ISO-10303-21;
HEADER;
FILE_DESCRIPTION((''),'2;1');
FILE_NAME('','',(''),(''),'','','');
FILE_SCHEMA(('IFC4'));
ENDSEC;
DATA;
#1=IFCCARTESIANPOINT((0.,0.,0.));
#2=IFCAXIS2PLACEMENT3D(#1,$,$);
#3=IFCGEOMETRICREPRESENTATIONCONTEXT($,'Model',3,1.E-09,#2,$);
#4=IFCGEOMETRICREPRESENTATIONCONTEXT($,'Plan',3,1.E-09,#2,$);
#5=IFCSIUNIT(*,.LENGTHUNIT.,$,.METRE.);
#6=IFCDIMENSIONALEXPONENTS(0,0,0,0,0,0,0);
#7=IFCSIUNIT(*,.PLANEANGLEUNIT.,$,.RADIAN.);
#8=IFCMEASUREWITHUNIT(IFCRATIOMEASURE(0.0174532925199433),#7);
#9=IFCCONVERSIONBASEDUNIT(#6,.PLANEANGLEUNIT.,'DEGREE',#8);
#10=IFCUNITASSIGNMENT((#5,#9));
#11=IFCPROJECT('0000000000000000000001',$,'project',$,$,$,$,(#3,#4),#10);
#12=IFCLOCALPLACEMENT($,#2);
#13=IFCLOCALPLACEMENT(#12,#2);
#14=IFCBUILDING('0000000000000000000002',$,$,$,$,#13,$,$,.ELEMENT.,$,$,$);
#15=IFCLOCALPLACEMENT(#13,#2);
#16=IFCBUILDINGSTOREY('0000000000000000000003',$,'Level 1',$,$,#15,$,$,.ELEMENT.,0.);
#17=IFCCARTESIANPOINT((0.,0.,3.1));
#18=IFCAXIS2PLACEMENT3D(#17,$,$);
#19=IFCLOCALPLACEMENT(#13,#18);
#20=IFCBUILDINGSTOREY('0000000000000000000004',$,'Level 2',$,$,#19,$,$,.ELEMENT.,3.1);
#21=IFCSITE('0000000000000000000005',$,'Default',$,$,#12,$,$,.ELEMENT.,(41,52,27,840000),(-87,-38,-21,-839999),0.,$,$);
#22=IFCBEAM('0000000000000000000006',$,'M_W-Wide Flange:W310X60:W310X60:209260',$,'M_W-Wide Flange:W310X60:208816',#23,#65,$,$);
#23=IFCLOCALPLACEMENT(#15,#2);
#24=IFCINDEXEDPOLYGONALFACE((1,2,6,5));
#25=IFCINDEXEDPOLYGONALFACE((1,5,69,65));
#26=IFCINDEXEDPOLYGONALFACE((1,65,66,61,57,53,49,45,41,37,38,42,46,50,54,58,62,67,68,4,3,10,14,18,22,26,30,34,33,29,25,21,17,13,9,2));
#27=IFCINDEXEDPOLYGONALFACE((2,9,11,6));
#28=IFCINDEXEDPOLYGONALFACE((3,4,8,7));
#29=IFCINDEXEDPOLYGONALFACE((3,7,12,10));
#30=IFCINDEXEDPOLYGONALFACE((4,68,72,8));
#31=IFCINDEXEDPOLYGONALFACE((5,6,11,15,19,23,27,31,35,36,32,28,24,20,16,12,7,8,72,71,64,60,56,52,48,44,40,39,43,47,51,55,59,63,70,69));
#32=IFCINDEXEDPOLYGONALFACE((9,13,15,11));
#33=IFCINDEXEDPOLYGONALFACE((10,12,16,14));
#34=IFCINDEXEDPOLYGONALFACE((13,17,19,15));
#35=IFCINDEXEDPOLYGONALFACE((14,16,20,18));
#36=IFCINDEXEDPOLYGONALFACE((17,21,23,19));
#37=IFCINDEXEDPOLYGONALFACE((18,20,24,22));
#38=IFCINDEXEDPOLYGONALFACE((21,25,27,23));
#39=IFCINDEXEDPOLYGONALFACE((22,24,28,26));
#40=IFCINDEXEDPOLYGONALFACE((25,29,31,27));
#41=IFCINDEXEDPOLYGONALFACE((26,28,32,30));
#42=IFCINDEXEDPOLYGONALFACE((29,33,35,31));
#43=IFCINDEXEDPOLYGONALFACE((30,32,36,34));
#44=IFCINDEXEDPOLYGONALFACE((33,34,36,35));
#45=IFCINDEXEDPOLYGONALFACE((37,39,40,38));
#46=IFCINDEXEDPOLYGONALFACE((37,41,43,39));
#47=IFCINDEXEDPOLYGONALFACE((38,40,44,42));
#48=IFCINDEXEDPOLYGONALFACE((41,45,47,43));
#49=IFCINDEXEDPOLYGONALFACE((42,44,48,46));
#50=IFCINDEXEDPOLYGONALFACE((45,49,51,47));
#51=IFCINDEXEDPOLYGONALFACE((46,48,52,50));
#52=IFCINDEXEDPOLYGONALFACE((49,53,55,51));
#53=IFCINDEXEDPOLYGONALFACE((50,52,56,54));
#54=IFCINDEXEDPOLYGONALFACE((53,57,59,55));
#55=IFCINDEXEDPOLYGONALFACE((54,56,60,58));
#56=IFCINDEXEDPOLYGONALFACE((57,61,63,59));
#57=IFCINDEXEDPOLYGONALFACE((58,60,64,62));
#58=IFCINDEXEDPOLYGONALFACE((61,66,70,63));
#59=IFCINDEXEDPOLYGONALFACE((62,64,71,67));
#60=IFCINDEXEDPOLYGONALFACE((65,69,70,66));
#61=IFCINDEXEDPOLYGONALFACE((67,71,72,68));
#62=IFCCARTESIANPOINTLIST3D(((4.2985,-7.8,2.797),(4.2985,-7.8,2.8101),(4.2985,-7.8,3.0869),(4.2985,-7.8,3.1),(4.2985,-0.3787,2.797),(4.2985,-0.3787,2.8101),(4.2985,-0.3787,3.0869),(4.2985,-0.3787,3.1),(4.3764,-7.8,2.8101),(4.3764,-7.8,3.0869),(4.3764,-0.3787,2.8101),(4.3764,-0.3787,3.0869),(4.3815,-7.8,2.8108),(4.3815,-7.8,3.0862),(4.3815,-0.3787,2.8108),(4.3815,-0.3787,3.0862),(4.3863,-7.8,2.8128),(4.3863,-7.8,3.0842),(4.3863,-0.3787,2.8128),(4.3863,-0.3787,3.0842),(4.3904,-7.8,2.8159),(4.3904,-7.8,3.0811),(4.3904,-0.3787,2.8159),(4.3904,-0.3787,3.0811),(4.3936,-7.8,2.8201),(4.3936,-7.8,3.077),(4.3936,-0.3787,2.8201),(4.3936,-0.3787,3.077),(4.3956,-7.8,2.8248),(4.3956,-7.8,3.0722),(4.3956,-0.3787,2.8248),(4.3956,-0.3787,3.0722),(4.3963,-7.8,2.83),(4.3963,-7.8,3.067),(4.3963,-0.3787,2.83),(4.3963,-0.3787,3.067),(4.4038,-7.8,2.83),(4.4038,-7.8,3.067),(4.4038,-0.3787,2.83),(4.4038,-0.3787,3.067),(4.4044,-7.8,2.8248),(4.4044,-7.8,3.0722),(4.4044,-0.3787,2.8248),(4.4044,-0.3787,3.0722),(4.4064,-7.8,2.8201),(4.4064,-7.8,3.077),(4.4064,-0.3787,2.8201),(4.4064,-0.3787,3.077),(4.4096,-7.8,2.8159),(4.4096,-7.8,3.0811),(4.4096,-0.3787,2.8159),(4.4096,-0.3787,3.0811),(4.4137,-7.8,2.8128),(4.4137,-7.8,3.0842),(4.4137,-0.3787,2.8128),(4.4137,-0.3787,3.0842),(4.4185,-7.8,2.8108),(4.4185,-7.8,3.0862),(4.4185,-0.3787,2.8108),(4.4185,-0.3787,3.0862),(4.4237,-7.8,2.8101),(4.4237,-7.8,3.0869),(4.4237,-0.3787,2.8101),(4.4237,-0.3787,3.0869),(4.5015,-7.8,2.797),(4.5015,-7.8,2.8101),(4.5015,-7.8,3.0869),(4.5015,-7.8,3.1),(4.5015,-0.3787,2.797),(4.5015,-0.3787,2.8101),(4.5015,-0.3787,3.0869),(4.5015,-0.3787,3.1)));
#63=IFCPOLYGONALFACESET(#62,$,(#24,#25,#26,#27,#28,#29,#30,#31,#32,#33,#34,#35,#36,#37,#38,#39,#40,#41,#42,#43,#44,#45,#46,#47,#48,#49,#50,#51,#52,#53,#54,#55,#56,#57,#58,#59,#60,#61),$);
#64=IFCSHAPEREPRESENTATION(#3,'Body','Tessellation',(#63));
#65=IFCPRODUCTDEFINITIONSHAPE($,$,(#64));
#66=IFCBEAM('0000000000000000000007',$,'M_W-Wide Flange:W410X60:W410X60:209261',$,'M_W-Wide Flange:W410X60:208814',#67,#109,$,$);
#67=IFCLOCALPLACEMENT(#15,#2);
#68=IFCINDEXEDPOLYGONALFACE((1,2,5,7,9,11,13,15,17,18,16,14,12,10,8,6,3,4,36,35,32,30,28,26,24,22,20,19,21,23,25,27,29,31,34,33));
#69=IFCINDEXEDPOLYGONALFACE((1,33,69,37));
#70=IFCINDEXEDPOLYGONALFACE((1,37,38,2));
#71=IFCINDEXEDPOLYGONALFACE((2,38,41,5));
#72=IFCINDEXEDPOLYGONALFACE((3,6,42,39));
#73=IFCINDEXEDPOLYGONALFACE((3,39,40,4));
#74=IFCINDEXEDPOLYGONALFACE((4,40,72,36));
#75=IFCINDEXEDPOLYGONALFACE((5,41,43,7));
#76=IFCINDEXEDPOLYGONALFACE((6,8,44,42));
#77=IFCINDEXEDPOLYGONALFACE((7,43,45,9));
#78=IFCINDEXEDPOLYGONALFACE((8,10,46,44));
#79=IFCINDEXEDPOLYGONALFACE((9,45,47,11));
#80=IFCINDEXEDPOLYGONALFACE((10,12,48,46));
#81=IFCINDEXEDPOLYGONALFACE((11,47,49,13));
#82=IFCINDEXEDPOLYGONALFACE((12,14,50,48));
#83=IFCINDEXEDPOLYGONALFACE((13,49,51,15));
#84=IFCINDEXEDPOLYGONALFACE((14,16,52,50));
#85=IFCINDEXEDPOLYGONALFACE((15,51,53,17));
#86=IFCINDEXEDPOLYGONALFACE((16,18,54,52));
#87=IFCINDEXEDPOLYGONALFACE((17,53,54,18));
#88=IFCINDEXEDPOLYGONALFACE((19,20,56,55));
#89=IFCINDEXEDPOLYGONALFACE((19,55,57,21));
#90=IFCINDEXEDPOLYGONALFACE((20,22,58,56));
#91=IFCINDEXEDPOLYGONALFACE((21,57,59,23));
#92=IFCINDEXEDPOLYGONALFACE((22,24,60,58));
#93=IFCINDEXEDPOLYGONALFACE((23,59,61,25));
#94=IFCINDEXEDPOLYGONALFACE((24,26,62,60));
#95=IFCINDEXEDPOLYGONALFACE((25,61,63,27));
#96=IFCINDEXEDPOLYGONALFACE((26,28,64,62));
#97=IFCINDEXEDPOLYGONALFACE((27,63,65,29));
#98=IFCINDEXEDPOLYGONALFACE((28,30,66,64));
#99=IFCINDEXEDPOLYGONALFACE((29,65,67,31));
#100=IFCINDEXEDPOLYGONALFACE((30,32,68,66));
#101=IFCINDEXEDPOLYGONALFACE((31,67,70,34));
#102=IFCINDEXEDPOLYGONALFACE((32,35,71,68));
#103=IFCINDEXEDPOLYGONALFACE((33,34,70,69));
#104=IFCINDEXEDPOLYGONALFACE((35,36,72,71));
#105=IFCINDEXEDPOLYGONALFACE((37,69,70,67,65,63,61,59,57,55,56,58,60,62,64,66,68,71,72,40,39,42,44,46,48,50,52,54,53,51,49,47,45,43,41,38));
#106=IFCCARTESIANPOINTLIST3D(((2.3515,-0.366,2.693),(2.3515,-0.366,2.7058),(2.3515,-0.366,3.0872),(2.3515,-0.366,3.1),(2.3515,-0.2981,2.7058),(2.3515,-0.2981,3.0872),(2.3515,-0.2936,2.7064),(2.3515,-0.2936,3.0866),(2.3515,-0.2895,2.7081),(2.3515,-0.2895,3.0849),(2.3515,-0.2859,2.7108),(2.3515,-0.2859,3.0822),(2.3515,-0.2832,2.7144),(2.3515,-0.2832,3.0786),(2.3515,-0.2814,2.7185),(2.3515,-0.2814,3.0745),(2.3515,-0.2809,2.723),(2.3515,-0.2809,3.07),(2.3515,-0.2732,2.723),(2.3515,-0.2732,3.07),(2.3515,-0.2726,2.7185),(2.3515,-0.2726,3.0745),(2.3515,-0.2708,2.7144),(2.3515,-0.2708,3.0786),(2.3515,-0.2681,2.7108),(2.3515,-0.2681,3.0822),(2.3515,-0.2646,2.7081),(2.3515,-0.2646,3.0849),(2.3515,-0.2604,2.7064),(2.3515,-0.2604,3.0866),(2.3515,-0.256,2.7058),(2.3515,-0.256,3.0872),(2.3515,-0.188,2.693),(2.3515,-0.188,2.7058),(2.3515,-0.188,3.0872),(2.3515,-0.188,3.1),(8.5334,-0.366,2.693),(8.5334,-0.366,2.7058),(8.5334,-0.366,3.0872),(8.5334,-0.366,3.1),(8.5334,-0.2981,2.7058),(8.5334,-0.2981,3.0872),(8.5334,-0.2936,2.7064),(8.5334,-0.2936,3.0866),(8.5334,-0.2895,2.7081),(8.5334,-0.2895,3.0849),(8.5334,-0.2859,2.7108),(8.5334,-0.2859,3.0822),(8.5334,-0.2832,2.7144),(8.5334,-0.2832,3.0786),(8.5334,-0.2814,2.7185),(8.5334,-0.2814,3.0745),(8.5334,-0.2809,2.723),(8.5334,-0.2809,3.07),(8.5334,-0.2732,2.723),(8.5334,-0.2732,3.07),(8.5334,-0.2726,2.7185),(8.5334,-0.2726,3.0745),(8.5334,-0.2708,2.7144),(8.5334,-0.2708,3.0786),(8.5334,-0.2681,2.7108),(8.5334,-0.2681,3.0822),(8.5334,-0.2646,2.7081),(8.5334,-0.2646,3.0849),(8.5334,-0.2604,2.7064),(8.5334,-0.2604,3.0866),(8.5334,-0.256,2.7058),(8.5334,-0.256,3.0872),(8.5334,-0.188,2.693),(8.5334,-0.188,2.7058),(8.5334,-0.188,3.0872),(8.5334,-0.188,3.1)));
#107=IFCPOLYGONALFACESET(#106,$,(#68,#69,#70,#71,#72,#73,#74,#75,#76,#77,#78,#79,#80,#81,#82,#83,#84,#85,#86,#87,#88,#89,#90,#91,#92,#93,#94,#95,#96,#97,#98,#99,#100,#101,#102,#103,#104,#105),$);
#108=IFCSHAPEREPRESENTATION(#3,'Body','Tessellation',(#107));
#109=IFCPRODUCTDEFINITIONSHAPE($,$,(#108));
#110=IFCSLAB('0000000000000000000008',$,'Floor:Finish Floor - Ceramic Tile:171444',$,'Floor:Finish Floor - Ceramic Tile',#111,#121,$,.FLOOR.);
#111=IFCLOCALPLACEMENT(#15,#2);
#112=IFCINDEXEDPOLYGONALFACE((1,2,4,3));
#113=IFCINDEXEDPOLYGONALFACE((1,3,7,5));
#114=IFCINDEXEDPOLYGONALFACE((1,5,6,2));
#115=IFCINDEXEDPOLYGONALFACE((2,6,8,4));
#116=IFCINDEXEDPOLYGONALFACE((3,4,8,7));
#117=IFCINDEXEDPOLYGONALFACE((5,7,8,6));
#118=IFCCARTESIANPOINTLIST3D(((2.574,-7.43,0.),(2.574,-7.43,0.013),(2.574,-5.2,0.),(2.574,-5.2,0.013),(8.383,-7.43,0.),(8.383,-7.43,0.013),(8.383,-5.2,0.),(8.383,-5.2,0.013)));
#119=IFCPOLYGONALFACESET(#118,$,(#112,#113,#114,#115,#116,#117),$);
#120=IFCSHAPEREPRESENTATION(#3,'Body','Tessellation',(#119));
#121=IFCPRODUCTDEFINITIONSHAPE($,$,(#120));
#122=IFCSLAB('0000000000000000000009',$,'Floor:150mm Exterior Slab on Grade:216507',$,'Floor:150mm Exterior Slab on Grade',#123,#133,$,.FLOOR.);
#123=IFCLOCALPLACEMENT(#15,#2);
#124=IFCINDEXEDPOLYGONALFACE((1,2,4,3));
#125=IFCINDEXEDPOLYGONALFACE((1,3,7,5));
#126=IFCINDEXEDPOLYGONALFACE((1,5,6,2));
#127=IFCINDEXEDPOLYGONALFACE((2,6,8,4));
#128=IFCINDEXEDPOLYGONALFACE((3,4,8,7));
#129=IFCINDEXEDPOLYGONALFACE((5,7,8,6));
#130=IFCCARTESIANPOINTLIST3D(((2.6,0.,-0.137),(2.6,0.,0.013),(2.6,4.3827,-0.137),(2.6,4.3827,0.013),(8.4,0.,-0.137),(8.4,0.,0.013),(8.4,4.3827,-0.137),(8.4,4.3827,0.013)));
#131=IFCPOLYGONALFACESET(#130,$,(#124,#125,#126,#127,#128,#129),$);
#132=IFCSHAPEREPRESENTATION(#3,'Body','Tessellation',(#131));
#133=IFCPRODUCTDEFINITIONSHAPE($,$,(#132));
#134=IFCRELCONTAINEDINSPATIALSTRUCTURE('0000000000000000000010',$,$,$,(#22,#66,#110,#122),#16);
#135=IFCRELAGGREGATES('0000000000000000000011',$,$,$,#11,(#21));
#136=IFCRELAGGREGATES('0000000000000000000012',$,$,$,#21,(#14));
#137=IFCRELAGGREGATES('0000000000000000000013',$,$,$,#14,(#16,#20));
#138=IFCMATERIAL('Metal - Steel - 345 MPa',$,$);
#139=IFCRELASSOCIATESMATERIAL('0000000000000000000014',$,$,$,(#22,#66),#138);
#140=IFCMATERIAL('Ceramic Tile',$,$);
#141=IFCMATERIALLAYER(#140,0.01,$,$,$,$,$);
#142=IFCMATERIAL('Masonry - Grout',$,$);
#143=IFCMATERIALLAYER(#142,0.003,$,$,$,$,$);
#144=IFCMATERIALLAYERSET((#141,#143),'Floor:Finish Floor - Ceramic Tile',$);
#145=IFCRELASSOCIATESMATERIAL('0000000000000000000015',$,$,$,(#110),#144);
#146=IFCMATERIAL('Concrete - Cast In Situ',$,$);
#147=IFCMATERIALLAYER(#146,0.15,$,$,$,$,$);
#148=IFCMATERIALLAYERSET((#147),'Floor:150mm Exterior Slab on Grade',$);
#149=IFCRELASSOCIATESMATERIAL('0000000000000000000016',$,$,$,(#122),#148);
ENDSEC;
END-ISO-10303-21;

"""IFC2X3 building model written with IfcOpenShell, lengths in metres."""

from ifc_helpers import new_model, entity, si_unit, converted_unit, frame, frame_2d, origin, place, context, project, spatial, polyline, circle_curve, parameter, trimmed, segment, composite_curve, rectangle, outline, extrude, material, layer, layer_set, layer_usage, element, save


model = new_model("IFC2X3")

# Units and contexts
model_context = context("Model", 3, precision=1e-09, world=origin())
plan_context = context("Plan", 3, precision=1e-09, world=origin())
ifc_project = project(units=[si_unit("LENGTHUNIT", "METRE"), converted_unit("PLANEANGLEUNIT", "DEGREE", entity("IfcRatioMeasure", 0.0174532925199433), si_unit("PLANEANGLEUNIT", "RADIAN"), dimensions=[0, 0, 0, 0, 0, 0, 0])], contexts=[model_context, plan_context])

# Site, building, storey
site_placement = place(None, origin())
site = spatial("IfcSite", under=ifc_project, at=site_placement, Name="Default", CompositionType="ELEMENT", RefLatitude=(41, 52, 27, 840000), RefLongitude=(-87, -38, -21, -839999), RefElevation=0.0)
building_placement = place(site_placement, origin())
building = spatial("IfcBuilding", under=site, at=building_placement, CompositionType="ELEMENT")
storey_1_placement = place(building_placement, origin())
storey_1 = spatial("IfcBuildingStorey", under=building, at=storey_1_placement, Name="Level 1", CompositionType="ELEMENT", Elevation=0.0)

# Beams
ifc_material_1 = material(Name="Metal - Steel - 345 MPa")
beam_1_placement = place(storey_1_placement, frame((4.4, -7.8, 3.1)))
element("IfcBeam", 1, at=beam_1_placement, inside=storey_1, material=ifc_material_1, Name="M_W-Wide Flange:W310X60:W310X60:209260", ObjectType="M_W-Wide Flange:W310X60:208816", context=model_context, shape_type="SweptSolid", body=[
    extrude(outline(composite_curve([segment(polyline([(-0.1015, -0.1384), (-0.1015, -0.1515)]), True, "CONTINUOUS"), segment(polyline([(-0.1015, -0.1515), (0.1015, -0.1515)]), True, "CONTINUOUS"), segment(polyline([(0.1015, -0.1515), (0.1015, -0.1384)]), True, "CONTINUOUS"), segment(polyline([(0.1015, -0.1384), (0.0236, -0.1384)]), True, "CONTINUOUS"), segment(trimmed(circle_curve(frame_2d((0.0236, -0.1185), x_axis=(1.0, 0.0)), 0.0199), [parameter(180.0)], [parameter(270.0)], True, "PARAMETER"), False, "CONTINUOUS"), segment(polyline([(0.0037, -0.1185), (0.0037, 0.1185)]), True, "CONTINUOUS"), segment(trimmed(circle_curve(frame_2d((0.0236, 0.1185), x_axis=(1.0, 0.0)), 0.0199), [parameter(90.0)], [parameter(180.0)], True, "PARAMETER"), False, "CONTINUOUS"), segment(polyline([(0.0236, 0.1384), (0.1015, 0.1384)]), True, "CONTINUOUS"), segment(polyline([(0.1015, 0.1384), (0.1015, 0.1515)]), True, "CONTINUOUS"), segment(polyline([(0.1015, 0.1515), (-0.1015, 0.1515)]), True, "CONTINUOUS"), segment(polyline([(-0.1015, 0.1515), (-0.1015, 0.1384)]), True, "CONTINUOUS"), segment(polyline([(-0.1015, 0.1384), (-0.0237, 0.1384)]), True, "CONTINUOUS"), segment(trimmed(circle_curve(frame_2d((-0.0237, 0.1185), x_axis=(1.0, 0.0)), 0.0199), [parameter(360.0)], [parameter(90.0)], True, "PARAMETER"), False, "CONTINUOUS"), segment(polyline([(-0.0038, 0.1185), (-0.0038, -0.1185)]), True, "CONTINUOUS"), segment(trimmed(circle_curve(frame_2d((-0.0237, -0.1185), x_axis=(1.0, 0.0)), 0.0199), [parameter(270.0)], [parameter(0.0)], True, "PARAMETER"), False, "CONTINUOUS"), segment(polyline([(-0.0237, -0.1384), (-0.1015, -0.1384)]), True, "CONTINUOUS")], self_intersect=False)), frame((0.0, 0.0, -0.1515), z_axis=(0.0, -1.0, 0.0), x_axis=(1.0, 0.0, 0.0)), (0.0, 0.0, -1.0), 7.4213),
])
beam_2_placement = place(storey_1_placement, frame((8.5915, -0.277, 3.1), z_axis=(0.0, 0.0, 1.0), x_axis=(0.0, 1.0, 0.0)))
element("IfcBeam", 2, at=beam_2_placement, inside=storey_1, material=ifc_material_1, Name="M_W-Wide Flange:W410X60:W410X60:209261", ObjectType="M_W-Wide Flange:W410X60:208814", context=model_context, shape_type="SweptSolid", body=[
    extrude(outline(composite_curve([segment(polyline([(0.1907, -0.089), (0.2035, -0.089)]), True, "CONTINUOUS"), segment(polyline([(0.2035, -0.089), (0.2035, 0.089)]), True, "CONTINUOUS"), segment(polyline([(0.2035, 0.089), (0.1907, 0.089)]), True, "CONTINUOUS"), segment(polyline([(0.1907, 0.089), (0.1907, 0.021)]), True, "CONTINUOUS"), segment(trimmed(circle_curve(frame_2d((0.1735, 0.021), x_axis=(1.0, 0.0)), 0.0172), [parameter(270.0)], [parameter(360.0)], True, "PARAMETER"), False, "CONTINUOUS"), segment(polyline([(0.1735, 0.0038), (-0.1735, 0.0038)]), True, "CONTINUOUS"), segment(trimmed(circle_curve(frame_2d((-0.1735, 0.021), x_axis=(0.0, -1.0)), 0.0172), [parameter(270.0)], [parameter(360.0)], True, "PARAMETER"), False, "CONTINUOUS"), segment(polyline([(-0.1907, 0.021), (-0.1907, 0.089)]), True, "CONTINUOUS"), segment(polyline([(-0.1907, 0.089), (-0.2035, 0.089)]), True, "CONTINUOUS"), segment(polyline([(-0.2035, 0.089), (-0.2035, -0.089)]), True, "CONTINUOUS"), segment(polyline([(-0.2035, -0.089), (-0.1907, -0.089)]), True, "CONTINUOUS"), segment(polyline([(-0.1907, -0.089), (-0.1907, -0.0211)]), True, "CONTINUOUS"), segment(trimmed(circle_curve(frame_2d((-0.1735, -0.0211), x_axis=(-1.0, 0.0)), 0.0172), [parameter(270.0)], [parameter(0.0)], True, "PARAMETER"), False, "CONTINUOUS"), segment(polyline([(-0.1735, -0.0039), (0.1735, -0.0039)]), True, "CONTINUOUS"), segment(trimmed(circle_curve(frame_2d((0.1735, -0.0211), x_axis=(0.0, 1.0)), 0.0172), [parameter(270.0)], [parameter(0.0)], True, "PARAMETER"), False, "CONTINUOUS"), segment(polyline([(0.1907, -0.0211), (0.1907, -0.089)]), True, "CONTINUOUS")], self_intersect=False)), frame((0.0, 6.24, -0.2035), z_axis=(0.0, -1.0, 0.0), x_axis=(0.0, 0.0, -1.0)), (0.0, 0.0, 1.0), 6.1819),
])

# Slabs
ifc_material_2 = material(Name="Ceramic Tile")
ifc_layer_1 = layer(ifc_material_2, 0.01)
ifc_material_3 = material(Name="Masonry - Grout")
ifc_layer_2 = layer(ifc_material_3, 0.003)
ifc_layer_set_1 = layer_set([ifc_layer_1, ifc_layer_2], Name="Floor:Finish Floor - Ceramic Tile")
ifc_layer_usage_1 = layer_usage(ifc_layer_set_1, "AXIS3", "POSITIVE", 0.0)
slab_1_placement = place(storey_1_placement, frame((2.574, -7.43, 0.0)))
element("IfcSlab", 3, at=slab_1_placement, inside=storey_1, material=ifc_layer_usage_1, Name="Floor:Finish Floor - Ceramic Tile:171444", ObjectType="Floor:Finish Floor - Ceramic Tile", PredefinedType="FLOOR", context=model_context, shape_type="SweptSolid", body=[
    extrude(rectangle(XDim=5.809, YDim=2.23, at=frame_2d((0.0, 0.0), x_axis=(-1.0, 0.0))), frame((2.9045, 1.115, 0.013), z_axis=(0.0, 0.0, -1.0), x_axis=(-1.0, 0.0, 0.0)), (0.0, 0.0, 1.0), 0.013),
])
ifc_material_4 = material(Name="Concrete - Cast In Situ")
ifc_layer_3 = layer(ifc_material_4, 0.15)
ifc_layer_set_2 = layer_set([ifc_layer_3], Name="Floor:150mm Exterior Slab on Grade")
ifc_layer_usage_2 = layer_usage(ifc_layer_set_2, "AXIS3", "POSITIVE", 0.0)
slab_2_placement = place(storey_1_placement, frame((2.6, 0.0, -0.137)))
element("IfcSlab", 4, at=slab_2_placement, inside=storey_1, material=ifc_layer_usage_2, Name="Floor:150mm Exterior Slab on Grade:216507", ObjectType="Floor:150mm Exterior Slab on Grade", PredefinedType="FLOOR", context=model_context, shape_type="SweptSolid", body=[
    extrude(rectangle(XDim=5.8, YDim=4.3827, at=frame_2d((0.0, 0.0), x_axis=(-1.0, 0.0))), frame((2.9, 2.1914, 0.15), z_axis=(0.0, 0.0, -1.0), x_axis=(-1.0, 0.0, 0.0)), (0.0, 0.0, 1.0), 0.15),
])

# Shared definitions
storey_2_placement = place(building_placement, frame((0.0, 0.0, 3.1)))
storey_2 = spatial("IfcBuildingStorey", under=building, at=storey_2_placement, Name="Level 2", CompositionType="ELEMENT", Elevation=3.1)

save(model, "model.ifc")
